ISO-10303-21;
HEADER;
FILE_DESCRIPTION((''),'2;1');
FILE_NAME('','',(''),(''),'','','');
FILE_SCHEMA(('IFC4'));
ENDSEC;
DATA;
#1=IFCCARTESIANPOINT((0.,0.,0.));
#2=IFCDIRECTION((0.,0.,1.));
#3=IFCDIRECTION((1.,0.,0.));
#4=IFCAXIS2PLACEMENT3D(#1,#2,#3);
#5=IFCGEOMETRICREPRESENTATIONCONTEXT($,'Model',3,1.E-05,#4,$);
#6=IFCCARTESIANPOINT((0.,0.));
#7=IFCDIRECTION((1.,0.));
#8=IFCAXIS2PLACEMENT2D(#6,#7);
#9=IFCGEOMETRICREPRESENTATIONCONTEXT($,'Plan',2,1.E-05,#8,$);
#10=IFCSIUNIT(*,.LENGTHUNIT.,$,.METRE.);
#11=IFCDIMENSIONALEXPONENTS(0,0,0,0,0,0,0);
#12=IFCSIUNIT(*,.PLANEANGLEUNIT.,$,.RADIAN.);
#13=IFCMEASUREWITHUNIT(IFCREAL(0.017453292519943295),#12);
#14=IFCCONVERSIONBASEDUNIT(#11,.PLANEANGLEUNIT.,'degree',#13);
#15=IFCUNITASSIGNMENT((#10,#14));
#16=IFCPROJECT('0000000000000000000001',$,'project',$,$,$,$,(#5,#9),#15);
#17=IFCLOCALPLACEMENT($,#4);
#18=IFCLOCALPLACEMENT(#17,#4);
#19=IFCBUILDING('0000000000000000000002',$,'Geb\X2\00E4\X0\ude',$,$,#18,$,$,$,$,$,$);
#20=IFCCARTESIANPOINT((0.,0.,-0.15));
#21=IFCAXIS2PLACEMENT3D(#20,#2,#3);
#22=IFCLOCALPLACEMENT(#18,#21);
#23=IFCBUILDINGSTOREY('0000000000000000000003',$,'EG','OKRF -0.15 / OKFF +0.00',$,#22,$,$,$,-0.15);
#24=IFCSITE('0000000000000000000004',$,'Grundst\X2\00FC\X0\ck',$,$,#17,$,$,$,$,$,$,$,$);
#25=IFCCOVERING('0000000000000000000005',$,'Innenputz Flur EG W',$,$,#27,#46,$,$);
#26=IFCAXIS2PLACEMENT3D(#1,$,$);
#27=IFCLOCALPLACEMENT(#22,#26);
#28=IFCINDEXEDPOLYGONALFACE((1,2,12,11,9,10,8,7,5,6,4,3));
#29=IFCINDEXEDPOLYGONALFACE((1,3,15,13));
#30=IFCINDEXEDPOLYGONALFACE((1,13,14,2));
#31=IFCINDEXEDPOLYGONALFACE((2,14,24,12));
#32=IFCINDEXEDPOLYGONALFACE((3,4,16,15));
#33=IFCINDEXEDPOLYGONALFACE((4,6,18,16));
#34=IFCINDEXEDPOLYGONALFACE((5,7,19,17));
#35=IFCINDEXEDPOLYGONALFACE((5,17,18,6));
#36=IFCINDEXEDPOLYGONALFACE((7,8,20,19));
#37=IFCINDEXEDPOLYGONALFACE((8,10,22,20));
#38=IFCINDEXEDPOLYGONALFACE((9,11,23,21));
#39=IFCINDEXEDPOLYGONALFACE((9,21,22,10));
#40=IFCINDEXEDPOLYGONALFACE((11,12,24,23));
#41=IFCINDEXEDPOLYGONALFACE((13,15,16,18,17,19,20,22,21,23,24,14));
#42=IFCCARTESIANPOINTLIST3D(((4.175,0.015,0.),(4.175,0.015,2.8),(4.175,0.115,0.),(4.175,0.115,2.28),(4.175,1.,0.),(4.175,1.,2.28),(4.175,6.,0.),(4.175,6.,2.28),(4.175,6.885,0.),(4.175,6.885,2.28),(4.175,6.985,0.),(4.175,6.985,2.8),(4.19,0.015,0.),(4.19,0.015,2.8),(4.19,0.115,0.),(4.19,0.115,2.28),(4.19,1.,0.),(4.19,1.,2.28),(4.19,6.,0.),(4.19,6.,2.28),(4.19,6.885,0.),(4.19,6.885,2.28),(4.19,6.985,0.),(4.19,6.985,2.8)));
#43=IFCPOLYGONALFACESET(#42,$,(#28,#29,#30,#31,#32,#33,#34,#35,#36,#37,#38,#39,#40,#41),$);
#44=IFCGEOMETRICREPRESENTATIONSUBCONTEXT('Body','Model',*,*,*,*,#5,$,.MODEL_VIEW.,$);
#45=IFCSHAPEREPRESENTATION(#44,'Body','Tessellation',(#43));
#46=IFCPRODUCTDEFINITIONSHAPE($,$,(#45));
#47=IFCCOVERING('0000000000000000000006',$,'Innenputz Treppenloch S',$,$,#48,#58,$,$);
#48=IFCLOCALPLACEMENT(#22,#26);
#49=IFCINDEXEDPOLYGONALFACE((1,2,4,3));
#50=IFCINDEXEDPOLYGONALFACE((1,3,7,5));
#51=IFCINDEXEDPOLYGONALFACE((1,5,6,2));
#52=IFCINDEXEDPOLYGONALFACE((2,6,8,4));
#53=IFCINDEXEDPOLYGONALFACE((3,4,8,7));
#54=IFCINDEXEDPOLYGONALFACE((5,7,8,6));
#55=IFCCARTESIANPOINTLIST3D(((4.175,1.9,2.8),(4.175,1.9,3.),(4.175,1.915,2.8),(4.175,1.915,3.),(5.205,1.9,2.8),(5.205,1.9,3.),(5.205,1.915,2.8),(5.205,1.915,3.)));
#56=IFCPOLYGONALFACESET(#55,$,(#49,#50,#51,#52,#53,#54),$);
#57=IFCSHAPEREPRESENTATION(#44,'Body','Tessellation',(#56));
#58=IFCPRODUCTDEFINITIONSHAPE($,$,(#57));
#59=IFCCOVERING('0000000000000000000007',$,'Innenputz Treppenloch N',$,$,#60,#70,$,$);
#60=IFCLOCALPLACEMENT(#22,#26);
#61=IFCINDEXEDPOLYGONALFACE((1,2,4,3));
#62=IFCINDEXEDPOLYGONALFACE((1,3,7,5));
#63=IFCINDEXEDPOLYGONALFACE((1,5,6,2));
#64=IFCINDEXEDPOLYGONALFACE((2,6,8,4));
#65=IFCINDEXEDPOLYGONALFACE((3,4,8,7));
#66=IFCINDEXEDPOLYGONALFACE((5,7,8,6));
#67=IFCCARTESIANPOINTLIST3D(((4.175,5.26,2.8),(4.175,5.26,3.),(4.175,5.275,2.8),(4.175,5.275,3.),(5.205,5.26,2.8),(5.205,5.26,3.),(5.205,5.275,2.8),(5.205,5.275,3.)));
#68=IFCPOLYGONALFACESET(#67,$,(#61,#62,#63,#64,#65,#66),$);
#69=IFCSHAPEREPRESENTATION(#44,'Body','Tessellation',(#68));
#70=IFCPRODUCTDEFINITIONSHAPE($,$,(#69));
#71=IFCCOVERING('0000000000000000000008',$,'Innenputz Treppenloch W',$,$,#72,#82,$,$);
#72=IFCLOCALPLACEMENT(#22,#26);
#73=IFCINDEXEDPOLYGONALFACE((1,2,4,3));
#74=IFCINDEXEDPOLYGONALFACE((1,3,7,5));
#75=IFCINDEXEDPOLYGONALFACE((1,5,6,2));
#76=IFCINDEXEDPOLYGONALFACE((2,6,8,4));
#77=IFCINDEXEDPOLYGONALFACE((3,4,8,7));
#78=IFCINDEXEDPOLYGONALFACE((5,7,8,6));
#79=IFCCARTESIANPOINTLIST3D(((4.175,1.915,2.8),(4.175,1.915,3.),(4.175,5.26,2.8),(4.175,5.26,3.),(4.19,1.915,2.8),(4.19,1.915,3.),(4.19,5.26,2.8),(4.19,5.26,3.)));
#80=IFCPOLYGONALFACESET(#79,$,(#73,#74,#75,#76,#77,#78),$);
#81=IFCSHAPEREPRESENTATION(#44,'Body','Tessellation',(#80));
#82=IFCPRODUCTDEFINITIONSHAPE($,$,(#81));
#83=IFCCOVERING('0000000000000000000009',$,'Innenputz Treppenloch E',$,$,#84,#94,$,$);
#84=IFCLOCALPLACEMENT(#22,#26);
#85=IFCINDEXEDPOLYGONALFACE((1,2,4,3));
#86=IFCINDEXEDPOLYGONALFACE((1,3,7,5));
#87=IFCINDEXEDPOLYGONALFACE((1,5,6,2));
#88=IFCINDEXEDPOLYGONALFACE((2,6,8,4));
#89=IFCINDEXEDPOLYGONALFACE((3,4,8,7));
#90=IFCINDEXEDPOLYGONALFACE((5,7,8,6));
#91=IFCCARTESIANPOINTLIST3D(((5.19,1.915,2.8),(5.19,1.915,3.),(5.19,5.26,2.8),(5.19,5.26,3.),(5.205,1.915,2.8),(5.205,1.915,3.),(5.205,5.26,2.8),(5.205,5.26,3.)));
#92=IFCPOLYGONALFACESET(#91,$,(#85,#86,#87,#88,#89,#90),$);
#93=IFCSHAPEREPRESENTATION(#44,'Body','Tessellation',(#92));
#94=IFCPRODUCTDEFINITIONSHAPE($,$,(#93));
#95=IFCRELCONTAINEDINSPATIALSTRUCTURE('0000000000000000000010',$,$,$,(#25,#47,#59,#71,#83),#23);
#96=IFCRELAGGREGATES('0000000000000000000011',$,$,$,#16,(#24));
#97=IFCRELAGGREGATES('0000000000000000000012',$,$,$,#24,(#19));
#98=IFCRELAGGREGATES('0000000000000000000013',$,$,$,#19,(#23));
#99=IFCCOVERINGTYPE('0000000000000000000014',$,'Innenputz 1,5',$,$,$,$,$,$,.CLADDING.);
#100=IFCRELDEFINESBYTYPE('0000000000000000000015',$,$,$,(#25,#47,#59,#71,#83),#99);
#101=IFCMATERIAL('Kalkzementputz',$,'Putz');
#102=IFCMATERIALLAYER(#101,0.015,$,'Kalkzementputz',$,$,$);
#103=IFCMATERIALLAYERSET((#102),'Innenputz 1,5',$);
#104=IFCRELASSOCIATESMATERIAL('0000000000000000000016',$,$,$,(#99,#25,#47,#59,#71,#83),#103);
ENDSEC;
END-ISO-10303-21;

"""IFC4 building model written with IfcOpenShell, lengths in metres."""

from ifc_helpers import new_model, entity, si_unit, converted_unit, frame, origin_with_axes, origin_2d_with_axis, place, context, subcontext, project, spatial, indexed_curve, outline, extrude, material, layer, layer_set, layer_usage, type_object, element, save


model = new_model("IFC4")

# Units and contexts
model_context = context("Model", 3, precision=1e-05, world=origin_with_axes())
plan_context = context("Plan", 2, precision=1e-05, world=origin_2d_with_axis())
body_context_1 = subcontext(model_context, "Body", "Model", "MODEL_VIEW")
ifc_project = project(units=[si_unit("LENGTHUNIT", "METRE"), converted_unit("PLANEANGLEUNIT", "degree", entity("IfcReal", 0.017453292519943295), si_unit("PLANEANGLEUNIT", "RADIAN"), dimensions=[0, 0, 0, 0, 0, 0, 0])], contexts=[model_context, plan_context])

# Site, building, storey
site_placement = place(None, origin_with_axes())
site = spatial("IfcSite", under=ifc_project, at=site_placement, Name="Grundstück")
building_placement = place(site_placement, origin_with_axes())
building = spatial("IfcBuilding", under=site, at=building_placement, Name="Gebäude")
storey_placement = place(building_placement, frame((0.0, 0.0, -0.15), z_axis=(0.0, 0.0, 1.0), x_axis=(1.0, 0.0, 0.0)))
storey = spatial("IfcBuildingStorey", under=building, at=storey_placement, Name="EG", Description="OKRF -0.15 / OKFF +0.00", Elevation=-0.15)

# Shared definitions
ifc_material_1 = material(Name="Kalkzementputz", Category="Putz")
ifc_layer_1 = layer(ifc_material_1, 0.015, Name="Kalkzementputz")
ifc_layer_set_1 = layer_set([ifc_layer_1], Name="Innenputz 1,5")
covering_type_1 = type_object("IfcCoveringType", Name="Innenputz 1,5", PredefinedType="CLADDING", material=ifc_layer_set_1)

# Covering, openings
ifc_layer_usage_1 = layer_usage(ifc_layer_set_1, "AXIS2", "POSITIVE", 0.0)
covering_1_placement = place(storey_placement, frame((4.175, 6.985, 0.0), z_axis=(0.0, 0.0, 1.0), x_axis=(0.0, -1.0, 0.0)))
covering_1 = element("IfcCovering", 1, at=covering_1_placement, inside=storey, type_object=covering_type_1, material=ifc_layer_usage_1, Name="Innenputz Flur EG W", context=body_context_1, shape_type="SweptSolid", body=[
    extrude(outline(indexed_curve([(0.0, 0.0), (0.0, 0.015), (6.97, 0.015), (6.97, 0.0), (0.0, 0.0)], self_intersect=False)), origin_with_axes(), (0.0, 0.0, 1.0), 2.8),
])
opening_1_placement = place(covering_1_placement, frame((0.1, -0.05, 0.0), z_axis=(0.0, 0.0, 1.0), x_axis=(1.0, 0.0, 0.0)))
element("IfcOpeningElement", 2, at=opening_1_placement, cuts=covering_1, context=body_context_1, shape_type="SweptSolid", body=[
    extrude(outline(indexed_curve([(0.0, 0.0), (0.0, 0.115), (0.885, 0.115), (0.885, 0.0), (0.0, 0.0)], self_intersect=False)), origin_with_axes(), (0.0, 0.0, 1.0), 2.28),
])
opening_2_placement = place(covering_1_placement, frame((5.985, -0.05, 0.0), z_axis=(0.0, 0.0, 1.0), x_axis=(1.0, 0.0, 0.0)))
element("IfcOpeningElement", 3, at=opening_2_placement, cuts=covering_1, context=body_context_1, shape_type="SweptSolid", body=[
    extrude(outline(indexed_curve([(0.0, 0.0), (0.0, 0.115), (0.885, 0.115), (0.885, 0.0), (0.0, 0.0)], self_intersect=False)), origin_with_axes(), (0.0, 0.0, 1.0), 2.28),
])

# Coverings
ifc_layer_usage_2 = layer_usage(ifc_layer_set_1, "AXIS2", "POSITIVE", 0.0)
covering_2_placement = place(storey_placement, frame((4.175, 1.9, 2.8), z_axis=(0.0, 0.0, 1.0), x_axis=(1.0, 0.0, 0.0)))
element("IfcCovering", 4, at=covering_2_placement, inside=storey, type_object=covering_type_1, material=ifc_layer_usage_2, Name="Innenputz Treppenloch S", context=body_context_1, shape_type="SweptSolid", body=[
    extrude(outline(indexed_curve([(0.0, 0.0), (0.0, 0.015), (1.03, 0.015), (1.03, 0.0), (0.0, 0.0)], self_intersect=False)), origin_with_axes(), (0.0, 0.0, 1.0), 0.2),
])
ifc_layer_usage_3 = layer_usage(ifc_layer_set_1, "AXIS2", "POSITIVE", 0.0)
covering_3_placement = place(storey_placement, frame((5.205, 5.275, 2.8), z_axis=(0.0, 0.0, 1.0), x_axis=(-1.0, 0.0, 0.0)))
element("IfcCovering", 5, at=covering_3_placement, inside=storey, type_object=covering_type_1, material=ifc_layer_usage_3, Name="Innenputz Treppenloch N", context=body_context_1, shape_type="SweptSolid", body=[
    extrude(outline(indexed_curve([(0.0, 0.0), (0.0, 0.015), (1.03, 0.015), (1.03, 0.0), (0.0, 0.0)], self_intersect=False)), origin_with_axes(), (0.0, 0.0, 1.0), 0.2),
])
ifc_layer_usage_4 = layer_usage(ifc_layer_set_1, "AXIS2", "POSITIVE", 0.0)
covering_4_placement = place(storey_placement, frame((4.175, 5.26, 2.8), z_axis=(0.0, 0.0, 1.0), x_axis=(0.0, -1.0, 0.0)))
element("IfcCovering", 6, at=covering_4_placement, inside=storey, type_object=covering_type_1, material=ifc_layer_usage_4, Name="Innenputz Treppenloch W", context=body_context_1, shape_type="SweptSolid", body=[
    extrude(outline(indexed_curve([(0.0, 0.0), (0.0, 0.015), (3.345, 0.015), (3.345, 0.0), (0.0, 0.0)], self_intersect=False)), origin_with_axes(), (0.0, 0.0, 1.0), 0.2),
])
ifc_layer_usage_5 = layer_usage(ifc_layer_set_1, "AXIS2", "POSITIVE", 0.0)
covering_5_placement = place(storey_placement, frame((5.205, 1.915, 2.8), z_axis=(0.0, 0.0, 1.0), x_axis=(0.0, 1.0, 0.0)))
element("IfcCovering", 7, at=covering_5_placement, inside=storey, type_object=covering_type_1, material=ifc_layer_usage_5, Name="Innenputz Treppenloch E", context=body_context_1, shape_type="SweptSolid", body=[
    extrude(outline(indexed_curve([(0.0, 0.0), (0.0, 0.015), (3.345, 0.015), (3.345, 0.0), (0.0, 0.0)], self_intersect=False)), origin_with_axes(), (0.0, 0.0, 1.0), 0.2),
])

save(model, "model.ifc")
